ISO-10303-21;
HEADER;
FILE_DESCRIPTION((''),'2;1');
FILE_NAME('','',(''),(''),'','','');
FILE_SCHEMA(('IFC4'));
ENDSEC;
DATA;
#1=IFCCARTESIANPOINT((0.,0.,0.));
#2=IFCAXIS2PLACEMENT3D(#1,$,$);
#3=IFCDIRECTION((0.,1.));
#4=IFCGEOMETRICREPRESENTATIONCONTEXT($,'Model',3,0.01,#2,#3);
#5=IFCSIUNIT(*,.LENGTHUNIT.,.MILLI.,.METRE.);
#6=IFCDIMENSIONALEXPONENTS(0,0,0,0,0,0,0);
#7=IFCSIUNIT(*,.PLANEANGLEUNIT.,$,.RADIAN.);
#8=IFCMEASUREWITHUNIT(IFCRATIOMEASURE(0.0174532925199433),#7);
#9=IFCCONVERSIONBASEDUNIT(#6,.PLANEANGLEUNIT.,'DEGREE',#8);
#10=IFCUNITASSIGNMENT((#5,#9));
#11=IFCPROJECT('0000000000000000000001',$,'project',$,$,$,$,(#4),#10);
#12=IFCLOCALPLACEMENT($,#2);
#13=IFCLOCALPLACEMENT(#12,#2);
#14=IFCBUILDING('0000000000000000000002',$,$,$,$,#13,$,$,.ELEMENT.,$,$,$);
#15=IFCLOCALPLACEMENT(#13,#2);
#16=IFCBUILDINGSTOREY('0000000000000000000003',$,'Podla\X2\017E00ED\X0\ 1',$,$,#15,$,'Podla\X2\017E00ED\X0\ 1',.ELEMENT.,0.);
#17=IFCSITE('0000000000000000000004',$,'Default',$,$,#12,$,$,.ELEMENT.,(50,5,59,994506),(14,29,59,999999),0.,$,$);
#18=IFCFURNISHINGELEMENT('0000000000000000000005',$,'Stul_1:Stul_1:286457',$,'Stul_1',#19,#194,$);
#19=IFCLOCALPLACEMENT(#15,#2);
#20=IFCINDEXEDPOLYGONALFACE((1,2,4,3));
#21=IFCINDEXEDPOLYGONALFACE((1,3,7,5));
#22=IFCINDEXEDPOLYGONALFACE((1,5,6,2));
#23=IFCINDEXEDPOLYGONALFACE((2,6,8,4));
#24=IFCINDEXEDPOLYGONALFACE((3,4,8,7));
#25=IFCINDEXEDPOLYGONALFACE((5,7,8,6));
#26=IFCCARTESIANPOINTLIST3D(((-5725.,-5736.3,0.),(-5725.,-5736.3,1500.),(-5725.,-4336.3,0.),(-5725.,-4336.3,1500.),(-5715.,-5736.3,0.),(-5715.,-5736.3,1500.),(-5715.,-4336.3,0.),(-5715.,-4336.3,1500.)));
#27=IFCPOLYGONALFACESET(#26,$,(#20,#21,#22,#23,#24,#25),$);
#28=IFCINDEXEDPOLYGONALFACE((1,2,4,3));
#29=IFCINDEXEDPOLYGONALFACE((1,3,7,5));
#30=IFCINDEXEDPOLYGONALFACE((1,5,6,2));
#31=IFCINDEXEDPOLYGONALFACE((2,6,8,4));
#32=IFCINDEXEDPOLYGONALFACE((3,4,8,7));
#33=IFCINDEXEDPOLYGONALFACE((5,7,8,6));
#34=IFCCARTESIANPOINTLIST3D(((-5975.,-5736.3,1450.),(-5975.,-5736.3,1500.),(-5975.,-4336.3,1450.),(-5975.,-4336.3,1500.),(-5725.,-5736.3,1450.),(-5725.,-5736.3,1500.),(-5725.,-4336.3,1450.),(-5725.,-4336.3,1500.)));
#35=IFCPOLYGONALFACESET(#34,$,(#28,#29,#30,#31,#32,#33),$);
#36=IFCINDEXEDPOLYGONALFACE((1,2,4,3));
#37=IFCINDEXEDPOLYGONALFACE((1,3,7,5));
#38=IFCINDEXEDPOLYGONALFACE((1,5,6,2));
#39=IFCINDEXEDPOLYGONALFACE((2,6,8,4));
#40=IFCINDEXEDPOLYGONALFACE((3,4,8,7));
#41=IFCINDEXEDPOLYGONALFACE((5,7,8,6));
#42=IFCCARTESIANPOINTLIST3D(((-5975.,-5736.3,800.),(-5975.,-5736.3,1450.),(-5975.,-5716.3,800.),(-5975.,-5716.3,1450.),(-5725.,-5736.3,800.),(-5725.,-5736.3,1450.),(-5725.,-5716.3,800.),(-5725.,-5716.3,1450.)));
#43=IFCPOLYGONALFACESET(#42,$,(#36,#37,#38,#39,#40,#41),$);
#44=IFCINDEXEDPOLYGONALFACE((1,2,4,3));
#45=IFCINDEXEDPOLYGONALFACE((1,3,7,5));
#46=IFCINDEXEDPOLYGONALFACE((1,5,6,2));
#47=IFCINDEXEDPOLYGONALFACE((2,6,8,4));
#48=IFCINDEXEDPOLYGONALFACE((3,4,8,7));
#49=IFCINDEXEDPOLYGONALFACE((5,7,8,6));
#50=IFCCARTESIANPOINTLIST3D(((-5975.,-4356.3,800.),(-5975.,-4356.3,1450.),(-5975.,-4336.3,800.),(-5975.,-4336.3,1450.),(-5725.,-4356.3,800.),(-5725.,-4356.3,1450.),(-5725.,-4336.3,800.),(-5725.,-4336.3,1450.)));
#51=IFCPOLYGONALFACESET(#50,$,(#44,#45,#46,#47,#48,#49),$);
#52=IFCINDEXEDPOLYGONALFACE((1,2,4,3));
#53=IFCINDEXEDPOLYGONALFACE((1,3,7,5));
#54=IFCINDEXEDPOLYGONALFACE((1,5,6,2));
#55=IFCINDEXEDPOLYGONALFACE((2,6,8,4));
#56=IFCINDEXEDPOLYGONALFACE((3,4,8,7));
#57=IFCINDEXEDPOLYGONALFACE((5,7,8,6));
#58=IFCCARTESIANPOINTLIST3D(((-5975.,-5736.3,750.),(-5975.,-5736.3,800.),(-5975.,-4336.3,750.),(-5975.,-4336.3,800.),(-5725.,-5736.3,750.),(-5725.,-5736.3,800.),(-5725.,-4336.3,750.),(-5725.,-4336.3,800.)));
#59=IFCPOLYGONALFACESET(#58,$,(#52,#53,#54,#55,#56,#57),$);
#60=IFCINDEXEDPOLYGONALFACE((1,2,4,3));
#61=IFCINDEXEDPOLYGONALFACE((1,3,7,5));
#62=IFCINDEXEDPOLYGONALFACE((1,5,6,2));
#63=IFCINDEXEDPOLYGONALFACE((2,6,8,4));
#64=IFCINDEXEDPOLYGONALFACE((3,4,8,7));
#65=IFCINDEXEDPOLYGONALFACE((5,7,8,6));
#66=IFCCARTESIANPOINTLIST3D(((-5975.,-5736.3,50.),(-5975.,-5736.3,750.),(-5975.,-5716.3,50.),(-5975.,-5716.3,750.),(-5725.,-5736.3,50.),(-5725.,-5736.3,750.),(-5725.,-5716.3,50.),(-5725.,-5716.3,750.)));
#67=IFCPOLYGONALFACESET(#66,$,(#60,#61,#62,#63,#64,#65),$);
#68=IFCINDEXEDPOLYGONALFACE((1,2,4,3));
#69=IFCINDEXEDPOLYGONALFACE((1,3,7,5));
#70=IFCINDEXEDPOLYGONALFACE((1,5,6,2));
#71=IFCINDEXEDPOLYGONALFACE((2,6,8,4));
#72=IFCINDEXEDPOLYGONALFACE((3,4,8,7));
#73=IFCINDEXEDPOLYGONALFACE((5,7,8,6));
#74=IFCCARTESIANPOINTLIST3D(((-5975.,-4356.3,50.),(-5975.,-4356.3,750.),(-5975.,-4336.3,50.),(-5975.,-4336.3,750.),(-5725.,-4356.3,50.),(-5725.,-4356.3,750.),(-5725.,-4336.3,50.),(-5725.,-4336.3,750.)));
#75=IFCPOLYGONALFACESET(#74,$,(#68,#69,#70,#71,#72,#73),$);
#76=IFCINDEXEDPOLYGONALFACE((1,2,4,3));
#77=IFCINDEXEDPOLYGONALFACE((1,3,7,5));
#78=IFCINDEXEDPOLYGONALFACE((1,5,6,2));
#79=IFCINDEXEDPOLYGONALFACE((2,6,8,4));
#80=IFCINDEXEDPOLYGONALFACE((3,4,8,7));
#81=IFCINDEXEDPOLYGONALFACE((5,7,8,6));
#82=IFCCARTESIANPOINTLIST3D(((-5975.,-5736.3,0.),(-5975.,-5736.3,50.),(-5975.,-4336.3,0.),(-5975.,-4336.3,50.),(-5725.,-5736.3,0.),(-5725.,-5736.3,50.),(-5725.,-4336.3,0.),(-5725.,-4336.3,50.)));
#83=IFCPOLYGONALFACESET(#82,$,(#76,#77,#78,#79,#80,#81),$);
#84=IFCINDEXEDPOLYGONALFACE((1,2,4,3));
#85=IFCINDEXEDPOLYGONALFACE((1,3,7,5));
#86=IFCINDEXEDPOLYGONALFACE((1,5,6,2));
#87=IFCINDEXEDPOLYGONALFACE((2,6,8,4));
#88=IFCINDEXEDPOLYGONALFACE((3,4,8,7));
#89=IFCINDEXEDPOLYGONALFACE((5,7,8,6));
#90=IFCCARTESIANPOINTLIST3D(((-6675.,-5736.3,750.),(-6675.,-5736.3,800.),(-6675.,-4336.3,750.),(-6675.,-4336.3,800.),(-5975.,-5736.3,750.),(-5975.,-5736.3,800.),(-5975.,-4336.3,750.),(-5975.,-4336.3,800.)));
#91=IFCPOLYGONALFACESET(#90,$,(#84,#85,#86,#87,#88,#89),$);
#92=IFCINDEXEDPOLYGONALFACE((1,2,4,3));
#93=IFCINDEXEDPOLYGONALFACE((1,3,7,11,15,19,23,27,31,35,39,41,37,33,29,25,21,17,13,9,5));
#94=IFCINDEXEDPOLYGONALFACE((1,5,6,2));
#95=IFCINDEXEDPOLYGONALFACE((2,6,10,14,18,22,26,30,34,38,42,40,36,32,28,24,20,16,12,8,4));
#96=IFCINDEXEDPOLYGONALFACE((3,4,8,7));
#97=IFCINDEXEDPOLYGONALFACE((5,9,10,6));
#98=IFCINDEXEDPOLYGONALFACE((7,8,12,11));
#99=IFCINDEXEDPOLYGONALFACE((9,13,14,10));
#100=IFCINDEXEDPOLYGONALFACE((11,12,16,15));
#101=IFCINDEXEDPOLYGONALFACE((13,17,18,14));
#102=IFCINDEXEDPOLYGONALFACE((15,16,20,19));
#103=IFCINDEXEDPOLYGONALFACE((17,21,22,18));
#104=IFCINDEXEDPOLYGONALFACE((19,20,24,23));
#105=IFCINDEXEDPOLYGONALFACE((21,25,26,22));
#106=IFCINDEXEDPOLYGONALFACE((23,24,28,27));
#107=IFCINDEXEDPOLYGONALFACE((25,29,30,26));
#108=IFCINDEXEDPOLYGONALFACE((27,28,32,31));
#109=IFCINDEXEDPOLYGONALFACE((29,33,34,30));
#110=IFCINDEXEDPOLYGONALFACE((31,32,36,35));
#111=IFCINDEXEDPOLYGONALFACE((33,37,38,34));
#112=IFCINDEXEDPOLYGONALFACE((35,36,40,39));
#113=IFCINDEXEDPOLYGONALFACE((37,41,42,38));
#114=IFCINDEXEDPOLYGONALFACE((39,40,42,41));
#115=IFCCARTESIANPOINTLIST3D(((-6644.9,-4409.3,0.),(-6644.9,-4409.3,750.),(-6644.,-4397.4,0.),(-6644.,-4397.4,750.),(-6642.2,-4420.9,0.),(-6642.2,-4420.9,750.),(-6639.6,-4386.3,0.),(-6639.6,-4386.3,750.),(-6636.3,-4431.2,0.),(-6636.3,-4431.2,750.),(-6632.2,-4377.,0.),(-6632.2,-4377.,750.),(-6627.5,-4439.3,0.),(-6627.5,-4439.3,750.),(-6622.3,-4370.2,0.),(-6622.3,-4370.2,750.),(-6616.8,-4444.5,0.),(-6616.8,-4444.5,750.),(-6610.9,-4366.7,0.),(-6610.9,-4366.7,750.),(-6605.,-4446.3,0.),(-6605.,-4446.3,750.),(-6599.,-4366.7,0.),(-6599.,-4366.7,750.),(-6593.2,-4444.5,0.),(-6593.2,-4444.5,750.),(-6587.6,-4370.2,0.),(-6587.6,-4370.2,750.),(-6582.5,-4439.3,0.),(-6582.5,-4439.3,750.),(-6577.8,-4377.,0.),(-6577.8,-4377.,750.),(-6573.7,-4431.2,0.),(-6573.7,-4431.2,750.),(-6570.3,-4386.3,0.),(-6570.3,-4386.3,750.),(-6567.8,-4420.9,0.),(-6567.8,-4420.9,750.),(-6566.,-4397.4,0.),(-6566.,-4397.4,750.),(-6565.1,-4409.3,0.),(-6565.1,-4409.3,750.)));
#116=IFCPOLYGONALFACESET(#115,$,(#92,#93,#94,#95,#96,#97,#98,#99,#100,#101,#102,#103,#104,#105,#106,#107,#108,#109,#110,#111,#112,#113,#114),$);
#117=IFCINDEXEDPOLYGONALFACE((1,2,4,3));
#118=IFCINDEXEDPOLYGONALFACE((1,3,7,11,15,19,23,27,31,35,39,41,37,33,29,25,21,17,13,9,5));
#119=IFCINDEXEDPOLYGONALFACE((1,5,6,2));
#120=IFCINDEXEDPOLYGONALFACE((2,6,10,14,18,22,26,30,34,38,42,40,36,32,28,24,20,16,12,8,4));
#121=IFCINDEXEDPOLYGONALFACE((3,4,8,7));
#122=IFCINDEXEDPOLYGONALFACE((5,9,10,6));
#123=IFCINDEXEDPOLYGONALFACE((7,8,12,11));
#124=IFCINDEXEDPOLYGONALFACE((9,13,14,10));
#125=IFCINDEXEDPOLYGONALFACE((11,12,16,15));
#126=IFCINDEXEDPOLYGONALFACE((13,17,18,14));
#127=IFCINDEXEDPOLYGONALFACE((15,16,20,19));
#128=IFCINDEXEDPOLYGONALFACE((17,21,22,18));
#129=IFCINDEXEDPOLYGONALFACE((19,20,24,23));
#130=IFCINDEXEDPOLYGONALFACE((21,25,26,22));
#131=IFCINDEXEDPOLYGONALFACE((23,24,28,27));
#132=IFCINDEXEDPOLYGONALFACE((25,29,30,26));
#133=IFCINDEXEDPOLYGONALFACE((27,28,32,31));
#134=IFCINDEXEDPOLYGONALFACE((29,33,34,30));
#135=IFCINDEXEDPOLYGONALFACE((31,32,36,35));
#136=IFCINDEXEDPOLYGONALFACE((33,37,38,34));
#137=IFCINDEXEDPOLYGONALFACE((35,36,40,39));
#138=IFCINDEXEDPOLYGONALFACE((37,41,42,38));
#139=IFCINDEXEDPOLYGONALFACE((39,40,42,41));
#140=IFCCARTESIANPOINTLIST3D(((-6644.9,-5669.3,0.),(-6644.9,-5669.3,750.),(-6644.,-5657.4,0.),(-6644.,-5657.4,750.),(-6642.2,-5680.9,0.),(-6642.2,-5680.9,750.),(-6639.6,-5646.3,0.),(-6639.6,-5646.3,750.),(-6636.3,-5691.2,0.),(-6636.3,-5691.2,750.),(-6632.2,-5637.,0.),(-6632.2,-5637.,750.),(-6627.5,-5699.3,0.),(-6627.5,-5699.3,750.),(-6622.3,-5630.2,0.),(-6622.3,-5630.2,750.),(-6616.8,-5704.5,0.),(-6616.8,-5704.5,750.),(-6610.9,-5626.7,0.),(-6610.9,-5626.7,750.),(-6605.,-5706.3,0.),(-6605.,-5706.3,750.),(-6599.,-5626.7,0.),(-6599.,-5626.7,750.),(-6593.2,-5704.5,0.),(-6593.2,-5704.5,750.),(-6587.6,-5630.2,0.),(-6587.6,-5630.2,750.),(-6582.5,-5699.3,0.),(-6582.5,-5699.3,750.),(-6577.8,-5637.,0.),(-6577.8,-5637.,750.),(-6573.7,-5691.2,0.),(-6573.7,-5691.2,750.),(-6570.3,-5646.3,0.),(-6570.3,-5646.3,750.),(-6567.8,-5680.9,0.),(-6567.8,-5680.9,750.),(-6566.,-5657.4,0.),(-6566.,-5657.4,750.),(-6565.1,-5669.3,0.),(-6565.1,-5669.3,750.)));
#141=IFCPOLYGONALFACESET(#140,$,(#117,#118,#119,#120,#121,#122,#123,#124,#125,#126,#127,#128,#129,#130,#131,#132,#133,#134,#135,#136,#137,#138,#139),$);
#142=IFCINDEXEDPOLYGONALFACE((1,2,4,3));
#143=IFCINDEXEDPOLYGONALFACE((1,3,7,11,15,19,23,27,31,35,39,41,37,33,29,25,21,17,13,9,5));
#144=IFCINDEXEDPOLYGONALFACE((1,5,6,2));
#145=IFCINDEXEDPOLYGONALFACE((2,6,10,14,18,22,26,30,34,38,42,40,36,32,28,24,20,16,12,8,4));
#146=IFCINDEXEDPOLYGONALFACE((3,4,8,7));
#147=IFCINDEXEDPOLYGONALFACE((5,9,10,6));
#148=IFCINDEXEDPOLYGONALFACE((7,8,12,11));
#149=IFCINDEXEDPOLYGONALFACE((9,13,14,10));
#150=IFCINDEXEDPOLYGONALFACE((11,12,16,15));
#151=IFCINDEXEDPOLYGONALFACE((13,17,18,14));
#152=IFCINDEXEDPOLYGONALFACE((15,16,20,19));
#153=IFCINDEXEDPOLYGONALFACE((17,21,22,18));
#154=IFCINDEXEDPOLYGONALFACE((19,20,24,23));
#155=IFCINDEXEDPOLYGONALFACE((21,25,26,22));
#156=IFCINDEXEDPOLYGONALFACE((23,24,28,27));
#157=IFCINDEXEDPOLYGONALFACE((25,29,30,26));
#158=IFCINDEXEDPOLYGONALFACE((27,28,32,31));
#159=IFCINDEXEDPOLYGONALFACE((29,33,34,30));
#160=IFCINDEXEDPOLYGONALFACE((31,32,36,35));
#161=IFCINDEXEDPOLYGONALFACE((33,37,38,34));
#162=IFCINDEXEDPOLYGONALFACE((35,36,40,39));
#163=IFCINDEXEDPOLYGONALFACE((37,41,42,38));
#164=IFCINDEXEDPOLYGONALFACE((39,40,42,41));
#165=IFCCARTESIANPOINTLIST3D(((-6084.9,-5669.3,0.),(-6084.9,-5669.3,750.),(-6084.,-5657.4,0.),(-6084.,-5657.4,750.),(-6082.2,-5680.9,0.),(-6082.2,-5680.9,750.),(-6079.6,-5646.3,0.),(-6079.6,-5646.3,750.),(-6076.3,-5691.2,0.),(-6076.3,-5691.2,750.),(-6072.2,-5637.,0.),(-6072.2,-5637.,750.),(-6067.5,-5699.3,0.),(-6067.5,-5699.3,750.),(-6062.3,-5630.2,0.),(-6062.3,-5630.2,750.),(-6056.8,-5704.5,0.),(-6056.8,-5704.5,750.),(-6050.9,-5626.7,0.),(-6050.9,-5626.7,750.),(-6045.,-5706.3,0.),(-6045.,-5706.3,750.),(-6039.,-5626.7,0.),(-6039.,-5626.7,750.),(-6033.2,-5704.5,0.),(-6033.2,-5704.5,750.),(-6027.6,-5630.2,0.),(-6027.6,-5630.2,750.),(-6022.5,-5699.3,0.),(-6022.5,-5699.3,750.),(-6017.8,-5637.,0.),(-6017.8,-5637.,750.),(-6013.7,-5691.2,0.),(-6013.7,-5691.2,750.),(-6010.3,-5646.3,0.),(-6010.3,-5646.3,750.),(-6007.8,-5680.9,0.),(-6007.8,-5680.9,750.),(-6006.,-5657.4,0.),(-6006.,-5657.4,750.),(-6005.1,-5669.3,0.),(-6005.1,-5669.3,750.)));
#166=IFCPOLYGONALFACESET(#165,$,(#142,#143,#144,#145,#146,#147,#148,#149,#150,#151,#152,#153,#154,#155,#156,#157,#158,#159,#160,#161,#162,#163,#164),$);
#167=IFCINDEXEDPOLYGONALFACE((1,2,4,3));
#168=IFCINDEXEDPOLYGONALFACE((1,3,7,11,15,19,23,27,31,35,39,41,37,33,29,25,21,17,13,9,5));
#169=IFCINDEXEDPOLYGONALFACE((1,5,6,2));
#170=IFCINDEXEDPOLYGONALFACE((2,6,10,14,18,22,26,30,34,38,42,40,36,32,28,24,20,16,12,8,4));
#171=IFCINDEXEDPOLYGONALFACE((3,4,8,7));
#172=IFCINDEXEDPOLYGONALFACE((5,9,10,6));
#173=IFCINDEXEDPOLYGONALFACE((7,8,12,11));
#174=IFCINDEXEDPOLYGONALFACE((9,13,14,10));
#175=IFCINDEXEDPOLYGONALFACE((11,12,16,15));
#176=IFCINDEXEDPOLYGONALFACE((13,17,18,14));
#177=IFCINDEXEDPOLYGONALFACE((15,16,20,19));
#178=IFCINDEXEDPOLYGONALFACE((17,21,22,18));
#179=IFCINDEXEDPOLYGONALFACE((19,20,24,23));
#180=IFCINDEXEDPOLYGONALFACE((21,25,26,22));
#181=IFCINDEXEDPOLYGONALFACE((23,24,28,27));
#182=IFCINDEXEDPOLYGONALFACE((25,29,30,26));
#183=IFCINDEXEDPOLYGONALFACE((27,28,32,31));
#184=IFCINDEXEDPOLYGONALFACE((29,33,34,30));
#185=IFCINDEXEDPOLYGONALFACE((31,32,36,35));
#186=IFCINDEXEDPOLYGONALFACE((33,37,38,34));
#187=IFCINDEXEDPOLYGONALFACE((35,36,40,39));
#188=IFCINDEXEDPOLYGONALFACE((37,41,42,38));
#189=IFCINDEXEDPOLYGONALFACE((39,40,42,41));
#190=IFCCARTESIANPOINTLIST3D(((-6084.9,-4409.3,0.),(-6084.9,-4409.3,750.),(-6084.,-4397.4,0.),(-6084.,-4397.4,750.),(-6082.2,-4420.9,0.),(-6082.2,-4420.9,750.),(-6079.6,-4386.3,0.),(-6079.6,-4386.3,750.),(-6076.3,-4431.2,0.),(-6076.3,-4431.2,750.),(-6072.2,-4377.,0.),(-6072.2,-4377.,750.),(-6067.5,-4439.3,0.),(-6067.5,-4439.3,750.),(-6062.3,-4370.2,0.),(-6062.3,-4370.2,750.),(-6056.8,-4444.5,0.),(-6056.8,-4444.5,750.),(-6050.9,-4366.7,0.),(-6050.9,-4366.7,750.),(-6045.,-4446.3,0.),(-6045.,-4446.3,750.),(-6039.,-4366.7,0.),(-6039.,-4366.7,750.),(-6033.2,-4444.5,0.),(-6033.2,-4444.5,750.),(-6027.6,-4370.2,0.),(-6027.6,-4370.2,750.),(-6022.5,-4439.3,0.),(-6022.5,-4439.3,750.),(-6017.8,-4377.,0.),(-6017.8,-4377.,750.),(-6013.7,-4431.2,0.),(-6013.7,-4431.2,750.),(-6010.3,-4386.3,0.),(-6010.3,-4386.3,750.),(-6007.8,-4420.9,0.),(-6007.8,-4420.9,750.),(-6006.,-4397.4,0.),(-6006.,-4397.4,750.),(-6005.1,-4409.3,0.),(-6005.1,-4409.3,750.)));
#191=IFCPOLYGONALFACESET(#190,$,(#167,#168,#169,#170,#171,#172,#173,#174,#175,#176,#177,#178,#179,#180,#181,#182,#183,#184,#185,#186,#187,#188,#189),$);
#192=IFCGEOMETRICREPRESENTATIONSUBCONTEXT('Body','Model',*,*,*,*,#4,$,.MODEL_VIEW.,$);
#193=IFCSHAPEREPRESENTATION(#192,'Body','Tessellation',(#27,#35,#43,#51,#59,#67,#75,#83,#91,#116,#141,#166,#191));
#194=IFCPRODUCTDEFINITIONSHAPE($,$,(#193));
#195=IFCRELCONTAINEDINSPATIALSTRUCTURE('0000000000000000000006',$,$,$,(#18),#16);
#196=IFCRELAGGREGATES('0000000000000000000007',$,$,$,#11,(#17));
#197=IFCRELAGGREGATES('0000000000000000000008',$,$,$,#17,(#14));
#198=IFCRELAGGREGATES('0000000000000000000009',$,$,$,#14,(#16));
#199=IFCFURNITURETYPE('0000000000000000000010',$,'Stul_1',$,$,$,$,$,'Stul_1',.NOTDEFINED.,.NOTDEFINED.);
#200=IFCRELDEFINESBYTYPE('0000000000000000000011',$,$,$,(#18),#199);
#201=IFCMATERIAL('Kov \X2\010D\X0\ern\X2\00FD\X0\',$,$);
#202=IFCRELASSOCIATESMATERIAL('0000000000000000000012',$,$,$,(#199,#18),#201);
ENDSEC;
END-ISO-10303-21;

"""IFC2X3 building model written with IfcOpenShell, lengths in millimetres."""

from ifc_helpers import new_model, entity, si_unit, converted_unit, direction, frame, frame_2d, origin, origin_2d_with_axis, place, context, subcontext, project, spatial, rectangle, circle, extrude, source, transform, mapped, material, type_object, type_shapes, element, save


model = new_model("IFC2X3")

# Units and contexts
model_context = context("Model", 3, precision=0.01, world=origin(), true_north=direction((0.0, 1.0)))
body_context = subcontext(model_context, "Body", "Model", "MODEL_VIEW")
ifc_project = project(units=[si_unit("LENGTHUNIT", "METRE", prefix="MILLI"), converted_unit("PLANEANGLEUNIT", "DEGREE", entity("IfcRatioMeasure", 0.0174532925199433), si_unit("PLANEANGLEUNIT", "RADIAN"), dimensions=[0, 0, 0, 0, 0, 0, 0])], contexts=[model_context])

# Site, building, storey
site_placement = place(None, origin())
site = spatial("IfcSite", under=ifc_project, at=site_placement, Name="Default", CompositionType="ELEMENT", RefLatitude=(50, 5, 59, 994506), RefLongitude=(14, 29, 59, 999999), RefElevation=0.0)
building_placement = place(site_placement, origin())
building = spatial("IfcBuilding", under=site, at=building_placement, CompositionType="ELEMENT")
storey_placement = place(building_placement, origin())
storey = spatial("IfcBuildingStorey", under=building, at=storey_placement, Name="Podlaží 1", LongName="Podlaží 1", CompositionType="ELEMENT", Elevation=0.0)

# Furnishing element
ifc_material_1 = material(Name="Kov černý")
furniture_type = type_object("IfcFurnitureType", Name="Stul_1", ElementType="Stul_1", material=ifc_material_1)
shared_shape_1 = source(origin(), body_context, "Body", "SweptSolid", [
    extrude(rectangle(XDim=1400.0, YDim=10.0, at=origin_2d_with_axis()), frame((0.0, 605.0, 0.0), z_axis=(0.0, 0.0, 1.0), x_axis=(-1.0, 0.0, 0.0)), (0.0, 0.0, 1.0), 1500.0),
    extrude(rectangle(XDim=1400.0, YDim=250.0, at=frame_2d((0.0, 0.0), x_axis=(1.0, 0.0))), frame((0.0, 475.0, 1450.0), z_axis=(0.0, 0.0, 1.0), x_axis=(-1.0, 0.0, 0.0)), (0.0, 0.0, 1.0), 50.0),
    extrude(rectangle(XDim=20.0, YDim=250.0, at=origin_2d_with_axis()), frame((690.0, 475.0, 800.0), z_axis=(0.0, 0.0, 1.0), x_axis=(-1.0, 0.0, 0.0)), (0.0, 0.0, 1.0), 650.0),
    extrude(rectangle(XDim=20.0, YDim=250.0, at=frame_2d((0.0, 0.0), x_axis=(1.0, 0.0))), frame((-690.0, 475.0, 800.0), z_axis=(0.0, 0.0, 1.0), x_axis=(-1.0, 0.0, 0.0)), (0.0, 0.0, 1.0), 650.0),
    extrude(rectangle(XDim=1400.0, YDim=250.0, at=origin_2d_with_axis()), frame((0.0, 475.0, 750.0), z_axis=(0.0, 0.0, 1.0), x_axis=(-1.0, 0.0, 0.0)), (0.0, 0.0, 1.0), 50.0),
    extrude(rectangle(XDim=20.0, YDim=250.0, at=origin_2d_with_axis()), frame((690.0, 475.0, 50.0), z_axis=(0.0, 0.0, 1.0), x_axis=(-1.0, 0.0, 0.0)), (0.0, 0.0, 1.0), 700.0),
    extrude(rectangle(XDim=20.0, YDim=250.0, at=frame_2d((0.0, 0.0), x_axis=(1.0, 0.0))), frame((-690.0, 475.0, 50.0), z_axis=(0.0, 0.0, 1.0), x_axis=(-1.0, 0.0, 0.0)), (0.0, 0.0, 1.0), 700.0),
    extrude(rectangle(XDim=1400.0, YDim=250.0, at=origin_2d_with_axis()), frame((0.0, 475.0, 0.0), z_axis=(0.0, 0.0, 1.0), x_axis=(-1.0, 0.0, 0.0)), (0.0, 0.0, 1.0), 50.0),
    extrude(rectangle(XDim=1400.0, YDim=700.0, at=origin_2d_with_axis()), frame((0.0, 0.0, 750.0), z_axis=(0.0, 0.0, 1.0), x_axis=(-1.0, 0.0, 0.0)), (0.0, 0.0, 1.0), 50.0),
    extrude(circle(Radius=40.0, at=frame_2d((0.0, 0.0), x_axis=(1.0, 0.0))), frame((-630.0, -280.0, 0.0)), (0.0, 0.0, 1.0), 750.0),
    extrude(circle(Radius=40.0, at=frame_2d((0.0, 0.0), x_axis=(1.0, 0.0))), frame((630.0, -280.0, 0.0)), (0.0, 0.0, 1.0), 750.0),
    extrude(circle(Radius=40.0, at=frame_2d((0.0, 0.0), x_axis=(1.0, 0.0))), frame((630.0, 280.0, 0.0)), (0.0, 0.0, 1.0), 750.0),
    extrude(circle(Radius=40.0, at=frame_2d((0.0, 0.0), x_axis=(1.0, 0.0))), frame((-630.0, 280.0, 0.0)), (0.0, 0.0, 1.0), 750.0),
])
type_shapes(furniture_type, [shared_shape_1])
for number, where, z_axis, x_axis, name in (
    (1, (-6325.0, -5036.3, 0.0), (0.0, 0.0, 1.0), (0.0, -1.0, 0.0), "Stul_1:Stul_1:286457"),
):
    element("IfcFurnishingElement", number, at=place(storey_placement, frame(where, z_axis=z_axis, x_axis=x_axis)), inside=storey, type_object=furniture_type, material=ifc_material_1, Name=name, ObjectType="Stul_1", context=body_context, shape_type="MappedRepresentation", body=[
        mapped(shared_shape_1, transform((0.0, 0.0, 0.0), scale=1.0)),
    ])

save(model, "model.ifc")
